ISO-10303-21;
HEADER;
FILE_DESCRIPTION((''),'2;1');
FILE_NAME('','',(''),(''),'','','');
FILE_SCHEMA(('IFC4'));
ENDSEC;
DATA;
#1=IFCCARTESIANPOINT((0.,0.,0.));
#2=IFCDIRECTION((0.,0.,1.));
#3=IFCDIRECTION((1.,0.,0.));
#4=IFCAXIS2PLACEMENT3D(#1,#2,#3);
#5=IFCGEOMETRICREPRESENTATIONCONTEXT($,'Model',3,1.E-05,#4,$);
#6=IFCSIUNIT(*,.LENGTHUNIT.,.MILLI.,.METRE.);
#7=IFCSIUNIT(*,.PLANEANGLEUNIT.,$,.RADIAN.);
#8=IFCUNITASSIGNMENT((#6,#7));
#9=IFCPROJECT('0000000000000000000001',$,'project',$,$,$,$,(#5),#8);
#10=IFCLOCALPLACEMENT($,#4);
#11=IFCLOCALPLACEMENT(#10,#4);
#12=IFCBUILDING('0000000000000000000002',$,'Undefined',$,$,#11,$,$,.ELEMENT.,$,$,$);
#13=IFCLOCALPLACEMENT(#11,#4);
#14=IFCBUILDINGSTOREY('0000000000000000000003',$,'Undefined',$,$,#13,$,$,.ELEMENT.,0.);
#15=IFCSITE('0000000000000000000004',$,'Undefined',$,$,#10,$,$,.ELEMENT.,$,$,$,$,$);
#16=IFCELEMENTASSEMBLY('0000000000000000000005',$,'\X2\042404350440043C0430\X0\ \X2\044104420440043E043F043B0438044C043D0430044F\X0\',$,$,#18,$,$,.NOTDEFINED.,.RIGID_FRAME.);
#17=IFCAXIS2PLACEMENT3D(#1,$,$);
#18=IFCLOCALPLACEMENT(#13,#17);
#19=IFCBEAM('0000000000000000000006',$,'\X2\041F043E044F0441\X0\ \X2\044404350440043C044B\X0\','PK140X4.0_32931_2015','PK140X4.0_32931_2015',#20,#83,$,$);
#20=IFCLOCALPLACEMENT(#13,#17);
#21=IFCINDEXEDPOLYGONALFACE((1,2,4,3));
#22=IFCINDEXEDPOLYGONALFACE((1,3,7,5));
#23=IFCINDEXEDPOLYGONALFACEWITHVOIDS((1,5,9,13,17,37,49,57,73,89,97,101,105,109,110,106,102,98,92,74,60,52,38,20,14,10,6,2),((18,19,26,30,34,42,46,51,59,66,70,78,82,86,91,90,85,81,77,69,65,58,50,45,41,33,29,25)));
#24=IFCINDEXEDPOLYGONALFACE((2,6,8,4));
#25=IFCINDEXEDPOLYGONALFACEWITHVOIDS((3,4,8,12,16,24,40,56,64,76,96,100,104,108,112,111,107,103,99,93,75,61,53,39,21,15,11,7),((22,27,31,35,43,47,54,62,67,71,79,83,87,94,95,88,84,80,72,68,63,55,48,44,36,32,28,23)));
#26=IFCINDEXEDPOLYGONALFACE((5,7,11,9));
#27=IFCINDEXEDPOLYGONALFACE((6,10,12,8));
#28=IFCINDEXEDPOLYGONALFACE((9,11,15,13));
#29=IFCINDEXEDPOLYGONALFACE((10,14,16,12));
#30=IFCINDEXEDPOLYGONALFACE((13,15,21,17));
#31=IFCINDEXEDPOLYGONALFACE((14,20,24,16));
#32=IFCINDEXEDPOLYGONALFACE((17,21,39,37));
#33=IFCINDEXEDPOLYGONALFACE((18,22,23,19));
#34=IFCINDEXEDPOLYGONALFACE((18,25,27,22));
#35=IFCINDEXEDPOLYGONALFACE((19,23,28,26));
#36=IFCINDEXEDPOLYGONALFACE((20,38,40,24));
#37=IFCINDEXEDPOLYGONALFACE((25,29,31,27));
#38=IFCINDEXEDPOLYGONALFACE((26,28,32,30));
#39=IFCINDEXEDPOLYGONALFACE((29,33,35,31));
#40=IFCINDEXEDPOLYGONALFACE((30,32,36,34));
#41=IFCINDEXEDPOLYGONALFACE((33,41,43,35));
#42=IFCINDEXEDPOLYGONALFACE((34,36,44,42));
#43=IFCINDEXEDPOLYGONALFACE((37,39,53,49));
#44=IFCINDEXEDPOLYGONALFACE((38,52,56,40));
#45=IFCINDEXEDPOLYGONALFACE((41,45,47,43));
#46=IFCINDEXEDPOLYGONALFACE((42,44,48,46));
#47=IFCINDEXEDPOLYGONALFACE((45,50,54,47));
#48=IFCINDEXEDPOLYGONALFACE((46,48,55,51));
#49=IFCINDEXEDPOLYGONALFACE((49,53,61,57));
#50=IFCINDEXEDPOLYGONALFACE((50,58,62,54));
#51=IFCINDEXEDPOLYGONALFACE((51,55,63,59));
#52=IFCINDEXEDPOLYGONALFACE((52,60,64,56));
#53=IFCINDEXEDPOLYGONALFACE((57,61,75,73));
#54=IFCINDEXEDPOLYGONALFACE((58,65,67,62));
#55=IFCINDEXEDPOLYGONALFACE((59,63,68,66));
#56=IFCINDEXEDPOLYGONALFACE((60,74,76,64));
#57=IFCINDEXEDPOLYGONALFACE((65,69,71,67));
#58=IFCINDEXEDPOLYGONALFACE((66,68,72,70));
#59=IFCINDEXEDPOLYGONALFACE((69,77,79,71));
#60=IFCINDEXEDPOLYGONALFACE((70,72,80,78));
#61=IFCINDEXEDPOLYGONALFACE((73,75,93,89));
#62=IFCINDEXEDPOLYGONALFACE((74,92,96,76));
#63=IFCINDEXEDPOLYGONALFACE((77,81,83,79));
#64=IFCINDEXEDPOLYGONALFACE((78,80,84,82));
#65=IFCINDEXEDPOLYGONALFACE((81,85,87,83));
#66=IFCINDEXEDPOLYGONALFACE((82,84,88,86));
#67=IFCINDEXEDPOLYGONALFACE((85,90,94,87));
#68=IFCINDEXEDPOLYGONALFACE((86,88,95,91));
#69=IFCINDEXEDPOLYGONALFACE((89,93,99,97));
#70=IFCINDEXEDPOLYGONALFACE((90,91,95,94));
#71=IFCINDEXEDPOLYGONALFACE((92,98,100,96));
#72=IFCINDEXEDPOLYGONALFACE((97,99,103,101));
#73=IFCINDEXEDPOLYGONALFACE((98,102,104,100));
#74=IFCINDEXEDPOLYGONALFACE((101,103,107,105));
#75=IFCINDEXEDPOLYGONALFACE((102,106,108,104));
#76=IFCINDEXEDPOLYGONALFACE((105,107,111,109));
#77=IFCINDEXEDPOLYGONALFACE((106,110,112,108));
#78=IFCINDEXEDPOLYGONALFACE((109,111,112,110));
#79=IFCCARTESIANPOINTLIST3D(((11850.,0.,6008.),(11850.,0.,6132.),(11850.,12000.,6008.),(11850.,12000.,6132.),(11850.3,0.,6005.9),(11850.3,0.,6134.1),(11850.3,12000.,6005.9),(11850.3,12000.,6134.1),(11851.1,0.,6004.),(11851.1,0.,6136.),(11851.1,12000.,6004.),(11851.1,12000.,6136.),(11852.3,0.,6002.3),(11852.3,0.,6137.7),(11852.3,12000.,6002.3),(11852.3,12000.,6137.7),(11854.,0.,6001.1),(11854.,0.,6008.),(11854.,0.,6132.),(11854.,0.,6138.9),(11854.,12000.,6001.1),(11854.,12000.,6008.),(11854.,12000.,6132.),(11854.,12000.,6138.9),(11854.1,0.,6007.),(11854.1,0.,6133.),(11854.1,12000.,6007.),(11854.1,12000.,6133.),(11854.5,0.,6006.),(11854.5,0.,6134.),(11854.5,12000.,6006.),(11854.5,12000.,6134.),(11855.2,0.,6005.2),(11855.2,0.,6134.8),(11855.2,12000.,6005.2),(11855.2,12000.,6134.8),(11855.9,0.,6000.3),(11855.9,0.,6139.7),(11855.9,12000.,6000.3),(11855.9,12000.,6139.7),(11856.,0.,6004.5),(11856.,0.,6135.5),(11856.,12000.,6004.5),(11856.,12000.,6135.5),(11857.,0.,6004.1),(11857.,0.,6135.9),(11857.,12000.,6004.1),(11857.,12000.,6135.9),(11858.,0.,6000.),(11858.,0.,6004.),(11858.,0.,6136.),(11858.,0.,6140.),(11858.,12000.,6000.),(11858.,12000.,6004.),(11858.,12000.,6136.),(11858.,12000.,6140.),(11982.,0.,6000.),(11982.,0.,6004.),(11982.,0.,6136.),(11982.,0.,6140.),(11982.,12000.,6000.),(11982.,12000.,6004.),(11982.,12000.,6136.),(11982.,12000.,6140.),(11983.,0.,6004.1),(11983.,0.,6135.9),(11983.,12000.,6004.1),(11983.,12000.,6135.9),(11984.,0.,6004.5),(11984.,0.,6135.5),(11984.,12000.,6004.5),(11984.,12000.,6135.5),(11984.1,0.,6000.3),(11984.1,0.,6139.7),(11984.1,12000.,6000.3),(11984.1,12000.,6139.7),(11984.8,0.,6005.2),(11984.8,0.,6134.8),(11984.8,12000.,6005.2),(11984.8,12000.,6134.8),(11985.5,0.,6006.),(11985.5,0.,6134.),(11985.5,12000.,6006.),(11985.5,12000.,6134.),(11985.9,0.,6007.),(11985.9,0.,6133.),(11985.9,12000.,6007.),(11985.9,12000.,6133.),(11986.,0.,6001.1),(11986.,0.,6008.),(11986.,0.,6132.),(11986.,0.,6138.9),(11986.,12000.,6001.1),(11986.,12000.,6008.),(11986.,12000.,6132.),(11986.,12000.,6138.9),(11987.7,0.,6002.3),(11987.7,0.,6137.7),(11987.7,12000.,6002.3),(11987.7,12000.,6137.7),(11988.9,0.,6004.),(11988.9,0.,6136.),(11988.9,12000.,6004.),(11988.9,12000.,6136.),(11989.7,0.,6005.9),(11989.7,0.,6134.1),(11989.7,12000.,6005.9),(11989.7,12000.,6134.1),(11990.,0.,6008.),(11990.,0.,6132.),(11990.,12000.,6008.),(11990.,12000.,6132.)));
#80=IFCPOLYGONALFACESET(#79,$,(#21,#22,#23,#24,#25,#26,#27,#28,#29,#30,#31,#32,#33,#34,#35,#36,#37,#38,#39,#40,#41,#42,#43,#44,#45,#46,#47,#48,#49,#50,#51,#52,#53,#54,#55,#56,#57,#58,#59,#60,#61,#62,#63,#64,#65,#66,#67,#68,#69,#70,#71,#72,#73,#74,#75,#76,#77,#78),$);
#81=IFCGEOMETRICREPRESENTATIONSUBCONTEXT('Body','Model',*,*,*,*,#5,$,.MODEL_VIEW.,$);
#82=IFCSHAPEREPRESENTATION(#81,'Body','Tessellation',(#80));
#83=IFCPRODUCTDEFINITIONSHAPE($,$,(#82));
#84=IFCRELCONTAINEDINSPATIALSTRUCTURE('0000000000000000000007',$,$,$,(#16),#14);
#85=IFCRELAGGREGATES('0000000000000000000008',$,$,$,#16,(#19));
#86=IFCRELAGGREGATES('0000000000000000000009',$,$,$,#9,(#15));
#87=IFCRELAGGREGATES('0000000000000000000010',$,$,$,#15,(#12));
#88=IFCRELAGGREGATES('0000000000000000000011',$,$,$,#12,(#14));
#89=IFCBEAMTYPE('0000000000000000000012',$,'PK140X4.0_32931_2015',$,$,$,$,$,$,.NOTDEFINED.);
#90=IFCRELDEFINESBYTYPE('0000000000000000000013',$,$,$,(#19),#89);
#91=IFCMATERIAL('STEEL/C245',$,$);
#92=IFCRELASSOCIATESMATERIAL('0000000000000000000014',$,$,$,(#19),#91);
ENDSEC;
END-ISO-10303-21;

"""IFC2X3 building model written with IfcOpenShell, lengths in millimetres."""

from ifc_helpers import new_model, si_unit, frame, origin_with_axes, origin_2d_with_axis, place, context, subcontext, project, spatial, hollow_rectangle, extrude, material, type_object, element, aggregate, save


model = new_model("IFC2X3")

# Units and contexts
model_context = context("Model", 3, precision=1e-05, world=origin_with_axes())
body_context = subcontext(model_context, "Body", "Model", "MODEL_VIEW")
ifc_project = project(units=[si_unit("LENGTHUNIT", "METRE", prefix="MILLI"), si_unit("PLANEANGLEUNIT", "RADIAN")], contexts=[model_context])

# Site, building, storey
site_placement = place(None, origin_with_axes())
site = spatial("IfcSite", under=ifc_project, at=site_placement, Name="Undefined", CompositionType="ELEMENT")
building_placement = place(site_placement, origin_with_axes())
building = spatial("IfcBuilding", under=site, at=building_placement, Name="Undefined", CompositionType="ELEMENT")
storey_placement = place(building_placement, origin_with_axes())
storey = spatial("IfcBuildingStorey", under=building, at=storey_placement, Name="Undefined", CompositionType="ELEMENT", Elevation=0.0)

# Shared definitions
ifc_material = material(Name="STEEL/C245")

# Element assembly, beam
assembly_1_placement = place(storey_placement, origin_with_axes())
assembly_1 = element("IfcElementAssembly", 1, at=assembly_1_placement, inside=storey, Name="Ферма строплиьная", AssemblyPlace="NOTDEFINED", PredefinedType="RIGID_FRAME")
beam_type_1 = type_object("IfcBeamType", Name="PK140X4.0_32931_2015", PredefinedType="NOTDEFINED")
beam_1_placement = place(assembly_1_placement, frame((11920.0, 0.0, 6070.0), z_axis=(0.0, 0.0, 1.0), x_axis=(0.0, 1.0, 0.0)))
beam_1 = element("IfcBeam", 2, at=beam_1_placement, type_object=beam_type_1, material=ifc_material, Name="Пояс фермы", Description="PK140X4.0_32931_2015", ObjectType="PK140X4.0_32931_2015", context=body_context, shape_type="SweptSolid", body=[
    extrude(hollow_rectangle(XDim=140.0, YDim=140.0, WallThickness=4.0, InnerFilletRadius=4.0, OuterFilletRadius=8.0, at=origin_2d_with_axis()), frame((12000.0, 0.0, 0.0), z_axis=(-1.0, 0.0, 0.0), x_axis=(0.0, -1.0, 0.0)), (0.0, 0.0, 1.0), 12000.0),
])
aggregate(assembly_1, [beam_1])

save(model, "model.ifc")
